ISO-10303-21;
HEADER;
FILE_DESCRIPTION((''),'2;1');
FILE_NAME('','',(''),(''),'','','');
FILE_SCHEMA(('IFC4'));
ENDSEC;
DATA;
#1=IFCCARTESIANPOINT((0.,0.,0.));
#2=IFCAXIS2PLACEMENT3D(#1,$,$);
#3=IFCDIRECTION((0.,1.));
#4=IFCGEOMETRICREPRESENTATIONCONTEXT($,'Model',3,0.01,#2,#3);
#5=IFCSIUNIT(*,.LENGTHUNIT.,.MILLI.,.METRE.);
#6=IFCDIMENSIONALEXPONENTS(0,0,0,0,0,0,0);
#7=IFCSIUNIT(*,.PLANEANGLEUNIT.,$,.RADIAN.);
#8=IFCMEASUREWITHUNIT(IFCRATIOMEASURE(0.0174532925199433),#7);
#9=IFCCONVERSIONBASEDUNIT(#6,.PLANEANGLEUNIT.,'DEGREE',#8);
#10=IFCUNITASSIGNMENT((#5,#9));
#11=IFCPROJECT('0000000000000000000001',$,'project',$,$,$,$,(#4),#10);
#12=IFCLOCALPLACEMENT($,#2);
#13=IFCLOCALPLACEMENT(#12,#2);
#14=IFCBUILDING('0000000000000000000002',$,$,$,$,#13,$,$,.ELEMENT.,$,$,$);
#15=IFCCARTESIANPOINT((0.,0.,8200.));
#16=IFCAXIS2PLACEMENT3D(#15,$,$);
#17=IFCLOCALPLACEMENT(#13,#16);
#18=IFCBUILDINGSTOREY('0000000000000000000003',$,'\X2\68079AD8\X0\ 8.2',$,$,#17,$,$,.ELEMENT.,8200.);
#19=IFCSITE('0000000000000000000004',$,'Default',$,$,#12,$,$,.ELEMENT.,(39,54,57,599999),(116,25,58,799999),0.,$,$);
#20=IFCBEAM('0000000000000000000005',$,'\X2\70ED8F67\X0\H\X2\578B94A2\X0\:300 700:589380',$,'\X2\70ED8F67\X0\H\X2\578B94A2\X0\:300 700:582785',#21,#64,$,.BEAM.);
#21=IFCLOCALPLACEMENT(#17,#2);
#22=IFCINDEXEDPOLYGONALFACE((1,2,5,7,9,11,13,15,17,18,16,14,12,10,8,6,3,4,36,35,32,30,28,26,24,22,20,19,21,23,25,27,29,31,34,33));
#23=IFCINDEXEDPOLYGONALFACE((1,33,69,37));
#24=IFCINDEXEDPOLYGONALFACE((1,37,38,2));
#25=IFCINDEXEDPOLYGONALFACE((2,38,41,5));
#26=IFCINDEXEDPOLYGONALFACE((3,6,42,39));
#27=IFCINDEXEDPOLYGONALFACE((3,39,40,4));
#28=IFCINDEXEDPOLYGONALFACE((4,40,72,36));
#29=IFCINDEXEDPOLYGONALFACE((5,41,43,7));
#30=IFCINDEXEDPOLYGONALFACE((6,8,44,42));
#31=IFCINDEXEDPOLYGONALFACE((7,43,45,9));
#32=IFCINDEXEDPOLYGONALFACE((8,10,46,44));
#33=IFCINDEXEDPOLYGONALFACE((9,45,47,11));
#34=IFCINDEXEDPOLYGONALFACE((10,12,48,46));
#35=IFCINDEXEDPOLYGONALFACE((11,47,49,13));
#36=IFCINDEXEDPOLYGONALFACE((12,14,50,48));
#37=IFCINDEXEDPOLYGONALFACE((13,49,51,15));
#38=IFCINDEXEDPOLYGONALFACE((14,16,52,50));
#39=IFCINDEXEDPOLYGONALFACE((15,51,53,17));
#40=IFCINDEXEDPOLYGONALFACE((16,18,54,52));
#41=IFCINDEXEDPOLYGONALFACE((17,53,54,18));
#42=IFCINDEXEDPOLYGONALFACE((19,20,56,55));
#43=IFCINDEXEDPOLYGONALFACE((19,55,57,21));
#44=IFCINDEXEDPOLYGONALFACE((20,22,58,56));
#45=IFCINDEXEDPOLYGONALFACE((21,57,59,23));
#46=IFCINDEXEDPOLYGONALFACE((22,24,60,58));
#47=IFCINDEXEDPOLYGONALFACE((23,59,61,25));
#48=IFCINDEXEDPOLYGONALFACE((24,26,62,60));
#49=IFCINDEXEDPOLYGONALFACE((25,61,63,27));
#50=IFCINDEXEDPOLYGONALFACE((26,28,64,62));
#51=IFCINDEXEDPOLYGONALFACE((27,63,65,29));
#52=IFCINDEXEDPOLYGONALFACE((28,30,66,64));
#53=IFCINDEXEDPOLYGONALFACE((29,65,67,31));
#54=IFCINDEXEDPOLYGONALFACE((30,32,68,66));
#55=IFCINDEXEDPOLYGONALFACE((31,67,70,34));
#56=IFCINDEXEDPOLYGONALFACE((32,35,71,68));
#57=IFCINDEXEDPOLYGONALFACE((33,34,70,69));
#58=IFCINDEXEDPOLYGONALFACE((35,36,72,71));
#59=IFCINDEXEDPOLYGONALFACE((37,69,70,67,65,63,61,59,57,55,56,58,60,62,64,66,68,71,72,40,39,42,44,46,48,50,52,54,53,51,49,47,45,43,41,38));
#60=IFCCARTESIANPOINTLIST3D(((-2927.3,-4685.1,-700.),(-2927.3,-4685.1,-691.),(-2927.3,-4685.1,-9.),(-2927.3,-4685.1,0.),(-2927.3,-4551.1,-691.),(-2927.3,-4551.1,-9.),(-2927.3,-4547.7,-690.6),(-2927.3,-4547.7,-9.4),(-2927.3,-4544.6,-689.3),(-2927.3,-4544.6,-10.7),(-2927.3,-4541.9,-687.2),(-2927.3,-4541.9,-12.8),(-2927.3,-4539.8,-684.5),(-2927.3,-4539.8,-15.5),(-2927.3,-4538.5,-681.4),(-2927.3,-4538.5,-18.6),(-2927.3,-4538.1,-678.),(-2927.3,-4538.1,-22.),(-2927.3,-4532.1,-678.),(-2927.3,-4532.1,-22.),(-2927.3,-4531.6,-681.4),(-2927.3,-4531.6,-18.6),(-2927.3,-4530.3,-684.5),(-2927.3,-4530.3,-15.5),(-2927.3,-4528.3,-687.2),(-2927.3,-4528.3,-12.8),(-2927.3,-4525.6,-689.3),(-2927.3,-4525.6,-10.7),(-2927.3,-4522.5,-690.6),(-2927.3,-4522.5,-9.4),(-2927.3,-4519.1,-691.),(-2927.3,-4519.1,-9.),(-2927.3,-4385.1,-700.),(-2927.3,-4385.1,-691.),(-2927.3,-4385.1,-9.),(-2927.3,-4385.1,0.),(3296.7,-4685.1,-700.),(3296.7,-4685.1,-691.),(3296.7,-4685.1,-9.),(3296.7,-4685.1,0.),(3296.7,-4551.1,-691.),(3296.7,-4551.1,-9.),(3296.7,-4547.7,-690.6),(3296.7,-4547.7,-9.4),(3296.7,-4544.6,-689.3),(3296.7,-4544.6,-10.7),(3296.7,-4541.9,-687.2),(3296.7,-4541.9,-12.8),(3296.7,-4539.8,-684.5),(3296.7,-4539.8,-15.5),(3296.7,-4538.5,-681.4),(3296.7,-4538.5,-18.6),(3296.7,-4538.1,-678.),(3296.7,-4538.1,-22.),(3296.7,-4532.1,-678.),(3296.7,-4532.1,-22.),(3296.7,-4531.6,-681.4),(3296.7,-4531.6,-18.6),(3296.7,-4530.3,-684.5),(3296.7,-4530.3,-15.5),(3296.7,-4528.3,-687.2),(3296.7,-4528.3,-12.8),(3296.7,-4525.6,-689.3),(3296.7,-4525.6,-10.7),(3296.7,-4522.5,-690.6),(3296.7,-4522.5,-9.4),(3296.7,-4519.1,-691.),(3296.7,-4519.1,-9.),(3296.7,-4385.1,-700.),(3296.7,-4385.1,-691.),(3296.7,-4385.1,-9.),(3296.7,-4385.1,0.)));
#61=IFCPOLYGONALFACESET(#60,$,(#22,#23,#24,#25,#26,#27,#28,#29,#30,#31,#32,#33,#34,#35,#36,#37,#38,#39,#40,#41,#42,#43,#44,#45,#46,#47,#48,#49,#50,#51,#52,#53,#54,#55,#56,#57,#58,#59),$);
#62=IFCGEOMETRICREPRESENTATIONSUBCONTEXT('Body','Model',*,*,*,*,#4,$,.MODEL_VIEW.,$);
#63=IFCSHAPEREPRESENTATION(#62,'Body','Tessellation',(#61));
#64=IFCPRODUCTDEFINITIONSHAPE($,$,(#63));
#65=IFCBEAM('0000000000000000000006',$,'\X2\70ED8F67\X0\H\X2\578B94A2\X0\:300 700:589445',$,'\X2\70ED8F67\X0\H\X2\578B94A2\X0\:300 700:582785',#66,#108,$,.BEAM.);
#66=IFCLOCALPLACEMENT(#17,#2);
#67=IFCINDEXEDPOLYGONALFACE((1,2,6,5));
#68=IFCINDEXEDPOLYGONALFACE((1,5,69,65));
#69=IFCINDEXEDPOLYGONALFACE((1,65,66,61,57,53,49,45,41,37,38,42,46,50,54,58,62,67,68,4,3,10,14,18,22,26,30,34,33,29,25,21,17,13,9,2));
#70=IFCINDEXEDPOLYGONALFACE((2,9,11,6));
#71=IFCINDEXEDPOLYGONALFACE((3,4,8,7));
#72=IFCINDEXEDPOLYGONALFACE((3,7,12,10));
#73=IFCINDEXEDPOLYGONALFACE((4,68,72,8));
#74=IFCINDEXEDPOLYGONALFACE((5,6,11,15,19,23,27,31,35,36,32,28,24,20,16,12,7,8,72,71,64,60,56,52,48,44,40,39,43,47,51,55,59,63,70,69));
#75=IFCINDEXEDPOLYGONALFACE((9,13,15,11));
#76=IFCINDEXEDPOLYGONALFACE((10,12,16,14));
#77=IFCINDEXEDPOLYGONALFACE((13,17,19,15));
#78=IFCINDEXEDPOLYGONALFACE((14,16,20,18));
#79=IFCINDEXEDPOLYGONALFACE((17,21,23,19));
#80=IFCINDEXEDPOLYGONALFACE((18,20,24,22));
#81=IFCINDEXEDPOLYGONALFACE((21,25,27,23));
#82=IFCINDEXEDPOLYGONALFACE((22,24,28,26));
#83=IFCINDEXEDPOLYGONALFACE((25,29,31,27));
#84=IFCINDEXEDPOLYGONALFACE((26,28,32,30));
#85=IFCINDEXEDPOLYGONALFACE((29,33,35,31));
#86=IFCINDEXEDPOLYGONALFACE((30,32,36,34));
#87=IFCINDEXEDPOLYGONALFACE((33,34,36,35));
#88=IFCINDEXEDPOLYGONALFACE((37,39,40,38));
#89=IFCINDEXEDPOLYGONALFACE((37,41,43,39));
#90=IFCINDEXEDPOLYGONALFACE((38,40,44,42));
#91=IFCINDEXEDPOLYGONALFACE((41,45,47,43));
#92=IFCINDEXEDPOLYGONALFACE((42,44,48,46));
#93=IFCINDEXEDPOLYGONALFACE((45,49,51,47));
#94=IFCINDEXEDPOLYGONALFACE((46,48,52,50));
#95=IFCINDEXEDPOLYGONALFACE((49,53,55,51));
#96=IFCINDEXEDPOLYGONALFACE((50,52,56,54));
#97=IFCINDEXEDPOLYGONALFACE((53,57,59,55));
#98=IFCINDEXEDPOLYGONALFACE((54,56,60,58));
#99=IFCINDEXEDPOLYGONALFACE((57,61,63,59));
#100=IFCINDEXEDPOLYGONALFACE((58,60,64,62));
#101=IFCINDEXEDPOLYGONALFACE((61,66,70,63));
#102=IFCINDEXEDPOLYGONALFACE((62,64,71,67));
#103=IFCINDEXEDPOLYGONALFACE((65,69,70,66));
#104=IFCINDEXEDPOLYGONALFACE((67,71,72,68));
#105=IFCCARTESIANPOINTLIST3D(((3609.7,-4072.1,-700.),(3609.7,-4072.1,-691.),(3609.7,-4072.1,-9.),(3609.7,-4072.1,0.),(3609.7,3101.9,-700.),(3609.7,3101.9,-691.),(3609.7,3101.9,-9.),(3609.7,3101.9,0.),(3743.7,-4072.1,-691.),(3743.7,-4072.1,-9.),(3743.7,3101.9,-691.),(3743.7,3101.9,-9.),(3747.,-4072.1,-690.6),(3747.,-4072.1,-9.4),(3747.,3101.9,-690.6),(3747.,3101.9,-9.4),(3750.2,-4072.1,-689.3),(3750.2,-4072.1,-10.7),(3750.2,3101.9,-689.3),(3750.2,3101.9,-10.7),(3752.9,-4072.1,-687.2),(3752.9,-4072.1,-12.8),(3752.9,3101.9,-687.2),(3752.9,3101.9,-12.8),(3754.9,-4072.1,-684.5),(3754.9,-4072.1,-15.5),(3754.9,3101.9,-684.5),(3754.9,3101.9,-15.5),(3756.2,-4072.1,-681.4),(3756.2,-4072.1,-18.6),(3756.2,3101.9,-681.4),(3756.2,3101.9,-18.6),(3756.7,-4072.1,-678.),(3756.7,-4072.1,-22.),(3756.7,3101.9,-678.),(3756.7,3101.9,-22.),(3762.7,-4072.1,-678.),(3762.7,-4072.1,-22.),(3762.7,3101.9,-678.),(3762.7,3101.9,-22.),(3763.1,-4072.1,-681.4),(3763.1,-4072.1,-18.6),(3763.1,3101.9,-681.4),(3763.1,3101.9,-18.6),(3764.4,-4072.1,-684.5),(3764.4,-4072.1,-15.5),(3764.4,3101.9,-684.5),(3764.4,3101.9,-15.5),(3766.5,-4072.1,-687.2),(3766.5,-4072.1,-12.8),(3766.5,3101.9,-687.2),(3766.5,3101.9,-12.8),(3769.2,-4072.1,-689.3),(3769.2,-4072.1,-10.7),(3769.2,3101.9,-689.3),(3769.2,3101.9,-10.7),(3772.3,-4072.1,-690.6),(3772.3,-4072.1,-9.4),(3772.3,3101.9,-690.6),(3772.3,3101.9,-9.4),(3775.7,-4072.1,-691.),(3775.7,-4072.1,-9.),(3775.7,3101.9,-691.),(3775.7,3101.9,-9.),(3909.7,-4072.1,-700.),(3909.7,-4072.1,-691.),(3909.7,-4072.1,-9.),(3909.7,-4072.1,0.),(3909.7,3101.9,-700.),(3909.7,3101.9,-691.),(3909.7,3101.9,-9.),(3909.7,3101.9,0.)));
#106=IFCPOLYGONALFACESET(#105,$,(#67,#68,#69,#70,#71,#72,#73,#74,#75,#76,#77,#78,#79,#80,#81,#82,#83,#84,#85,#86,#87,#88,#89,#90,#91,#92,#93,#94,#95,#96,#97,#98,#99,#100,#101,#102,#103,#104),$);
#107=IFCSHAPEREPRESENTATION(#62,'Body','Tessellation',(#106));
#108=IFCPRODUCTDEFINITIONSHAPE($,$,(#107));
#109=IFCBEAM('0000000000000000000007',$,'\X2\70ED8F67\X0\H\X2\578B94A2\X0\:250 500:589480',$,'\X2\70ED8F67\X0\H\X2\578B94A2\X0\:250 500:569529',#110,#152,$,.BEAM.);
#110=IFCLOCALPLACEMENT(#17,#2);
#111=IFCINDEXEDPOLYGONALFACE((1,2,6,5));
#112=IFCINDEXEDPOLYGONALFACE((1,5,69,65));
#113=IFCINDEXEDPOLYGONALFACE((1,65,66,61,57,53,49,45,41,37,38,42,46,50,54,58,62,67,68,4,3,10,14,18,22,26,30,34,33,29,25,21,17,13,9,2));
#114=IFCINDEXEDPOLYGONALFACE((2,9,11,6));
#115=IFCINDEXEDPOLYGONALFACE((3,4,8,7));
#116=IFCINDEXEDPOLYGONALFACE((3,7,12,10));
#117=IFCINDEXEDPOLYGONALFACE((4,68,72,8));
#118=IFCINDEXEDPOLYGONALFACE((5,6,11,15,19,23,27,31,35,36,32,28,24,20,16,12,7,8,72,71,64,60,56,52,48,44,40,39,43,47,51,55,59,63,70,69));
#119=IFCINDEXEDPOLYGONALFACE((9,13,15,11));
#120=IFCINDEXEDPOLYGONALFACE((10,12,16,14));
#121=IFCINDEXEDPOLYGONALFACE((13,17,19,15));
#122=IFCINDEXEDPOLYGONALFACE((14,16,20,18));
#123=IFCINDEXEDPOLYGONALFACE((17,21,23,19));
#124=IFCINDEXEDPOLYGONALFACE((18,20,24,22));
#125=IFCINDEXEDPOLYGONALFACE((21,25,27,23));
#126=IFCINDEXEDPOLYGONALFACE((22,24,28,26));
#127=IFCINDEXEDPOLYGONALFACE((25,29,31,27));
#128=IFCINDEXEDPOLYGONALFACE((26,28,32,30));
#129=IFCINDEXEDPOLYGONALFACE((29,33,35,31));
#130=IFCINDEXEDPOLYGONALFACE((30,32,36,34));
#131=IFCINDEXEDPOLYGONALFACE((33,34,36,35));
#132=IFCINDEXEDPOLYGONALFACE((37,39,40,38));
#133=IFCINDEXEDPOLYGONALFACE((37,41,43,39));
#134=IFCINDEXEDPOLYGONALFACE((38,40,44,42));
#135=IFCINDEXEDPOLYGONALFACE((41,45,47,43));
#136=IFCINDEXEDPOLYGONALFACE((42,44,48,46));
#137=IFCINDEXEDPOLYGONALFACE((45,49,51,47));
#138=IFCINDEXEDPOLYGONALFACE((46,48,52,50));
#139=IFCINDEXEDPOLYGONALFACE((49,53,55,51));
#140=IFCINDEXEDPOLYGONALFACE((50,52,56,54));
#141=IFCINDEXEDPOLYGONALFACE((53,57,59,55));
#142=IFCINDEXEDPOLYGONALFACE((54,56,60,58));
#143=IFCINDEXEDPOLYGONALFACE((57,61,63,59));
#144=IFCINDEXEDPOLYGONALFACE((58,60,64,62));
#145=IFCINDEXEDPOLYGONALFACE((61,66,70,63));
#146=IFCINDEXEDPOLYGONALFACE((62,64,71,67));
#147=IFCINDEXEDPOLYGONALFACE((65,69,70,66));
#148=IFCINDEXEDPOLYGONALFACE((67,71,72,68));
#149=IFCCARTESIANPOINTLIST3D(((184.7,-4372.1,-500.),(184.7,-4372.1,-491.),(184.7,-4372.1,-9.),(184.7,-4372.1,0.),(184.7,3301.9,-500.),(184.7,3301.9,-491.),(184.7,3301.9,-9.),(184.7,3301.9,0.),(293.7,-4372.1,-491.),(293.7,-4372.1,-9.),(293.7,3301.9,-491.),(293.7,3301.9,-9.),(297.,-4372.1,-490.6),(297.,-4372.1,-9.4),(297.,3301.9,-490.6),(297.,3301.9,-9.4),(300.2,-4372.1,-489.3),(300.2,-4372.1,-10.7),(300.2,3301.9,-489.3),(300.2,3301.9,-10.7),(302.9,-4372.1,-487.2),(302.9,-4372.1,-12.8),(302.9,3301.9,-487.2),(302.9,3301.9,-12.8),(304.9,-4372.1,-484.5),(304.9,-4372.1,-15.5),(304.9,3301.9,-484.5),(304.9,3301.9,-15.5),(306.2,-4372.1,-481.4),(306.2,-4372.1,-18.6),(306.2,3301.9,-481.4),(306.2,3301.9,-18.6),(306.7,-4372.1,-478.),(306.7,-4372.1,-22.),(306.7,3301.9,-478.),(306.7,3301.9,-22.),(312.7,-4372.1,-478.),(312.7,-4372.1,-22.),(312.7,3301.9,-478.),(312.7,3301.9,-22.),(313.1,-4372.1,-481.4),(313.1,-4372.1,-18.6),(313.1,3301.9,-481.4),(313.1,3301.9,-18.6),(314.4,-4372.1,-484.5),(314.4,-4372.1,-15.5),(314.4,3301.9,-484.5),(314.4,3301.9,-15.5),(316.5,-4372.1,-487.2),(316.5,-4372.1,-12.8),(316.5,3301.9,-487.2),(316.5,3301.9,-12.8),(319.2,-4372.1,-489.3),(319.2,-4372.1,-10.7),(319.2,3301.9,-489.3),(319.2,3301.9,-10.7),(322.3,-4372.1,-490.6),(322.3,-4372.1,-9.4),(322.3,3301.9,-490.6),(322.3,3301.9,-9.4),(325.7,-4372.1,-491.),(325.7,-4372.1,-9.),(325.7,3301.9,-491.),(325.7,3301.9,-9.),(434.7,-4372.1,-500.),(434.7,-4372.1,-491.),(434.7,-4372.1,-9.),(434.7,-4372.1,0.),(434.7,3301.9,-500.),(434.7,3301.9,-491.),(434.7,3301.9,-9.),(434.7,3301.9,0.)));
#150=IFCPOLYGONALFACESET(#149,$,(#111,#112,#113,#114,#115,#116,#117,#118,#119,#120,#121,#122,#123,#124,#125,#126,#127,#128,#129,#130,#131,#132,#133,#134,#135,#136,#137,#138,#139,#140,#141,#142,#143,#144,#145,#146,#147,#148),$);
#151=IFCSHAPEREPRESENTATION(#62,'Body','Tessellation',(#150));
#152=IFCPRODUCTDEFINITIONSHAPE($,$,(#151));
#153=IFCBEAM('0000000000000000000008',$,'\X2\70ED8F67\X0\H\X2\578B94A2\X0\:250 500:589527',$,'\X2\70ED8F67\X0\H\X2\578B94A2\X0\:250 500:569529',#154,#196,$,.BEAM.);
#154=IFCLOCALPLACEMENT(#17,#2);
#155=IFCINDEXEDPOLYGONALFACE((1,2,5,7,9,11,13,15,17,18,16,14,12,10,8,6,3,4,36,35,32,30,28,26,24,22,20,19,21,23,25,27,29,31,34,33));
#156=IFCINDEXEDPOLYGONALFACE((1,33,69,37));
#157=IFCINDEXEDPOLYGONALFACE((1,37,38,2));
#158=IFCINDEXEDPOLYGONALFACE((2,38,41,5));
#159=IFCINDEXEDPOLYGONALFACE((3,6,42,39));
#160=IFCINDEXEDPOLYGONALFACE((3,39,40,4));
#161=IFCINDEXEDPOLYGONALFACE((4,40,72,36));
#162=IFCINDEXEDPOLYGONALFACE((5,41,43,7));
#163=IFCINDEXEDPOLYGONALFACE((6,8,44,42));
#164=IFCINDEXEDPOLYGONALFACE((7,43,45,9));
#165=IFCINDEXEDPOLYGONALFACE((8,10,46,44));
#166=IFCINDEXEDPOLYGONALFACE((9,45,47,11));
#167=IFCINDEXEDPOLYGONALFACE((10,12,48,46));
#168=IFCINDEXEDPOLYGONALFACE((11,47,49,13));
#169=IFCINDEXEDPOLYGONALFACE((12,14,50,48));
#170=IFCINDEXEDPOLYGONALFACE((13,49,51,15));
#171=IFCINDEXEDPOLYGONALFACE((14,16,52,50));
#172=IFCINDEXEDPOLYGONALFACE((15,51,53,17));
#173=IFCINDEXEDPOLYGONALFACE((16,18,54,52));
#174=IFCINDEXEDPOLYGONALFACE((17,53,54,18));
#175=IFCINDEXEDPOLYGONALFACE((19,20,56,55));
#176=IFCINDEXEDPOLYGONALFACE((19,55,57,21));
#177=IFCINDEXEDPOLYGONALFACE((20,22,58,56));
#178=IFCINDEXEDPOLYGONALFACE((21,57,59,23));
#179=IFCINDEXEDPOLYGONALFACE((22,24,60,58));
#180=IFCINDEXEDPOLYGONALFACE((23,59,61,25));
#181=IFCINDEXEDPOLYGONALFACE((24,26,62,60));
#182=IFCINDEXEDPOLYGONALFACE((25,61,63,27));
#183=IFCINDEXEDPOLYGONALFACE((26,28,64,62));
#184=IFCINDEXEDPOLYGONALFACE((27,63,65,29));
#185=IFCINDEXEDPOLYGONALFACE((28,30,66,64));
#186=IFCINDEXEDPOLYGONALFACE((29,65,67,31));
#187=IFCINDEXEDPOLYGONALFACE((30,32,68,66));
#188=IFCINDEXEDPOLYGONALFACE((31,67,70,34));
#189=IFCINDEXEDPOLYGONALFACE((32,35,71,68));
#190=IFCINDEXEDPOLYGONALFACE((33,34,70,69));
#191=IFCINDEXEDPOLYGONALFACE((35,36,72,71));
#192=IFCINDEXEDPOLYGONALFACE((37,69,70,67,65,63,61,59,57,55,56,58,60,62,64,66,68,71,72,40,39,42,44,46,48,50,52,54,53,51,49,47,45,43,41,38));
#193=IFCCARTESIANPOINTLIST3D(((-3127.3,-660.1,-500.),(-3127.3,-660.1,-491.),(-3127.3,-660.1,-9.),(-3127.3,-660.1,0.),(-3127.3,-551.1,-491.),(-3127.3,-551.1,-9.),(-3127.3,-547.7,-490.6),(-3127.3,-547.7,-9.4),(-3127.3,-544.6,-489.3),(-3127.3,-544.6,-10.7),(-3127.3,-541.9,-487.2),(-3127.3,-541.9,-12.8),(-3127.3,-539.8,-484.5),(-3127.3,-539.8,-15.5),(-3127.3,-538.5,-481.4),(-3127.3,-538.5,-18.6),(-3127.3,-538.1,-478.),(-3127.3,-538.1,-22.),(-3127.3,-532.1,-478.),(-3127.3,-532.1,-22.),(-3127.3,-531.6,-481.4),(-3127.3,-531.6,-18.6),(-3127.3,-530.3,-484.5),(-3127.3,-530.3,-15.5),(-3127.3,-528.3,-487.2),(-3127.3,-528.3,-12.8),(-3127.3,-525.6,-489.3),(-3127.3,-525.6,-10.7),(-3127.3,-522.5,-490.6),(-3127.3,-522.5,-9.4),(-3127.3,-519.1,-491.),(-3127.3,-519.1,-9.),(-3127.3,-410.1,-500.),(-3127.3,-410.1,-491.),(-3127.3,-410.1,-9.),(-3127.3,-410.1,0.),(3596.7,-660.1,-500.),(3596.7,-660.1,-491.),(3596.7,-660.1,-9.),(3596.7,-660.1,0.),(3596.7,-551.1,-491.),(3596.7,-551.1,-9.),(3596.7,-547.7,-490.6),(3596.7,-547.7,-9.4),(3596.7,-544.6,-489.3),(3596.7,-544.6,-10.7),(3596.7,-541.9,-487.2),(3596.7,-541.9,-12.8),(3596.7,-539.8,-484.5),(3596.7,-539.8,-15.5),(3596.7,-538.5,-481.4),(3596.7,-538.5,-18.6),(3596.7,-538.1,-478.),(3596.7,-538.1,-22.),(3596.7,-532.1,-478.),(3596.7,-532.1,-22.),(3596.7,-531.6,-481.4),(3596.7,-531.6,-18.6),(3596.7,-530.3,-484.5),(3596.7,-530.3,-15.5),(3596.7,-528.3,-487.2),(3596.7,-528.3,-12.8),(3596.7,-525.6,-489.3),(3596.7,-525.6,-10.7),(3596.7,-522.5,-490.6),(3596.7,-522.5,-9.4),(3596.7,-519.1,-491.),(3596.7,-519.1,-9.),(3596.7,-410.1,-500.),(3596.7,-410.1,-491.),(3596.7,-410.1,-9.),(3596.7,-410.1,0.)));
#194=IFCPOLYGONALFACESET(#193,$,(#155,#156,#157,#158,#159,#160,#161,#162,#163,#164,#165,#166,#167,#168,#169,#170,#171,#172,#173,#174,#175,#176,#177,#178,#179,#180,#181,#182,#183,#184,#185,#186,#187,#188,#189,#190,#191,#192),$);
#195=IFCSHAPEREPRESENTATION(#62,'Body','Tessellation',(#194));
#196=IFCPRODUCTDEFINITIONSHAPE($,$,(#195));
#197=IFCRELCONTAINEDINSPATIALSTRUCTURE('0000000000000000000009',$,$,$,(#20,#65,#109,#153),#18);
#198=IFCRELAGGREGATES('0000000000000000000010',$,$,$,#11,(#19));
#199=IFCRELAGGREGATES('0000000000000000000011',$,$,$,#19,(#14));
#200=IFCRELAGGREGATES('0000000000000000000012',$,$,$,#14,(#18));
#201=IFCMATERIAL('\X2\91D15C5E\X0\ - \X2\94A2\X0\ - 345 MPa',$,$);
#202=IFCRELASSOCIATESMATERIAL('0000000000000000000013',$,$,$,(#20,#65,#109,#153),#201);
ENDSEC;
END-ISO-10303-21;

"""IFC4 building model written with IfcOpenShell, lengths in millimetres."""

from ifc_helpers import new_model, entity, si_unit, converted_unit, direction, frame, frame_2d, origin, place, context, subcontext, project, spatial, i_section, extrude, material, element, save


model = new_model("IFC4")

# Units and contexts
model_context = context("Model", 3, precision=0.01, world=origin(), true_north=direction((0.0, 1.0)))
body_context = subcontext(model_context, "Body", "Model", "MODEL_VIEW")
ifc_project = project(units=[si_unit("LENGTHUNIT", "METRE", prefix="MILLI"), converted_unit("PLANEANGLEUNIT", "DEGREE", entity("IfcRatioMeasure", 0.0174532925199433), si_unit("PLANEANGLEUNIT", "RADIAN"), dimensions=[0, 0, 0, 0, 0, 0, 0])], contexts=[model_context])

# Site, building, storey
site_placement = place(None, origin())
site = spatial("IfcSite", under=ifc_project, at=site_placement, Name="Default", CompositionType="ELEMENT", RefLatitude=(39, 54, 57, 599999), RefLongitude=(116, 25, 58, 799999), RefElevation=0.0)
building_placement = place(site_placement, origin())
building = spatial("IfcBuilding", under=site, at=building_placement, CompositionType="ELEMENT")
storey_placement = place(building_placement, frame((0.0, 0.0, 8200.0)))
storey = spatial("IfcBuildingStorey", under=building, at=storey_placement, Name="标高 8.2", CompositionType="ELEMENT", Elevation=8200.0)

# Beams
ifc_material_1 = material(Name="金属 - 钢 - 345 MPa")
beam_1_placement = place(storey_placement, frame((3309.7, -4535.1, 0.0), z_axis=(0.0, 0.0, 1.0), x_axis=(-1.0, 0.0, 0.0)))
element("IfcBeam", 1, at=beam_1_placement, inside=storey, material=ifc_material_1, Name="热轧H型钢:300 700:589380", ObjectType="热轧H型钢:300 700:582785", PredefinedType="BEAM", context=body_context, shape_type="SweptSolid", body=[
    extrude(i_section(OverallWidth=300.0, OverallDepth=700.0, WebThickness=6.0, FlangeThickness=9.0, FilletRadius=13.0, at=frame_2d((0.0, 0.0), x_axis=(0.0, 1.0))), frame((13.0, 0.0, -350.0), z_axis=(1.0, 0.0, 0.0), x_axis=(0.0, 0.0, -1.0)), (0.0, 0.0, 1.0), 6224.0),
])
beam_2_placement = place(storey_placement, frame((3759.7, 3114.9, 0.0), z_axis=(0.0, 0.0, 1.0), x_axis=(0.0, -1.0, 0.0)))
element("IfcBeam", 2, at=beam_2_placement, inside=storey, material=ifc_material_1, Name="热轧H型钢:300 700:589445", ObjectType="热轧H型钢:300 700:582785", PredefinedType="BEAM", context=body_context, shape_type="SweptSolid", body=[
    extrude(i_section(OverallWidth=300.0, OverallDepth=700.0, WebThickness=6.0, FlangeThickness=9.0, FilletRadius=13.0, at=frame_2d((0.0, 0.0), x_axis=(0.0, 1.0))), frame((13.0, 0.0, -350.0), z_axis=(1.0, 0.0, 0.0), x_axis=(0.0, 0.0, -1.0)), (0.0, 0.0, 1.0), 7174.0),
])
beam_3_placement = place(storey_placement, frame((309.7, 3464.9, 0.0), z_axis=(0.0, 0.0, 1.0), x_axis=(0.0, -1.0, 0.0)))
element("IfcBeam", 3, at=beam_3_placement, inside=storey, material=ifc_material_1, Name="热轧H型钢:250 500:589480", ObjectType="热轧H型钢:250 500:569529", PredefinedType="BEAM", context=body_context, shape_type="SweptSolid", body=[
    extrude(i_section(OverallWidth=250.0, OverallDepth=500.0, WebThickness=6.0, FlangeThickness=9.0, FilletRadius=13.0, at=frame_2d((0.0, 0.0), x_axis=(0.0, 1.0))), frame((163.0, 0.0, -250.0), z_axis=(1.0, 0.0, 0.0), x_axis=(0.0, 0.0, -1.0)), (0.0, 0.0, 1.0), 7674.0),
])
beam_4_placement = place(storey_placement, frame((-3290.3, -535.1, 0.0)))
element("IfcBeam", 4, at=beam_4_placement, inside=storey, material=ifc_material_1, Name="热轧H型钢:250 500:589527", ObjectType="热轧H型钢:250 500:569529", PredefinedType="BEAM", context=body_context, shape_type="SweptSolid", body=[
    extrude(i_section(OverallWidth=250.0, OverallDepth=500.0, WebThickness=6.0, FlangeThickness=9.0, FilletRadius=13.0, at=frame_2d((0.0, 0.0), x_axis=(0.0, 1.0))), frame((163.0, 0.0, -250.0), z_axis=(1.0, 0.0, 0.0), x_axis=(0.0, 0.0, -1.0)), (0.0, 0.0, 1.0), 6724.0),
])

save(model, "model.ifc")
